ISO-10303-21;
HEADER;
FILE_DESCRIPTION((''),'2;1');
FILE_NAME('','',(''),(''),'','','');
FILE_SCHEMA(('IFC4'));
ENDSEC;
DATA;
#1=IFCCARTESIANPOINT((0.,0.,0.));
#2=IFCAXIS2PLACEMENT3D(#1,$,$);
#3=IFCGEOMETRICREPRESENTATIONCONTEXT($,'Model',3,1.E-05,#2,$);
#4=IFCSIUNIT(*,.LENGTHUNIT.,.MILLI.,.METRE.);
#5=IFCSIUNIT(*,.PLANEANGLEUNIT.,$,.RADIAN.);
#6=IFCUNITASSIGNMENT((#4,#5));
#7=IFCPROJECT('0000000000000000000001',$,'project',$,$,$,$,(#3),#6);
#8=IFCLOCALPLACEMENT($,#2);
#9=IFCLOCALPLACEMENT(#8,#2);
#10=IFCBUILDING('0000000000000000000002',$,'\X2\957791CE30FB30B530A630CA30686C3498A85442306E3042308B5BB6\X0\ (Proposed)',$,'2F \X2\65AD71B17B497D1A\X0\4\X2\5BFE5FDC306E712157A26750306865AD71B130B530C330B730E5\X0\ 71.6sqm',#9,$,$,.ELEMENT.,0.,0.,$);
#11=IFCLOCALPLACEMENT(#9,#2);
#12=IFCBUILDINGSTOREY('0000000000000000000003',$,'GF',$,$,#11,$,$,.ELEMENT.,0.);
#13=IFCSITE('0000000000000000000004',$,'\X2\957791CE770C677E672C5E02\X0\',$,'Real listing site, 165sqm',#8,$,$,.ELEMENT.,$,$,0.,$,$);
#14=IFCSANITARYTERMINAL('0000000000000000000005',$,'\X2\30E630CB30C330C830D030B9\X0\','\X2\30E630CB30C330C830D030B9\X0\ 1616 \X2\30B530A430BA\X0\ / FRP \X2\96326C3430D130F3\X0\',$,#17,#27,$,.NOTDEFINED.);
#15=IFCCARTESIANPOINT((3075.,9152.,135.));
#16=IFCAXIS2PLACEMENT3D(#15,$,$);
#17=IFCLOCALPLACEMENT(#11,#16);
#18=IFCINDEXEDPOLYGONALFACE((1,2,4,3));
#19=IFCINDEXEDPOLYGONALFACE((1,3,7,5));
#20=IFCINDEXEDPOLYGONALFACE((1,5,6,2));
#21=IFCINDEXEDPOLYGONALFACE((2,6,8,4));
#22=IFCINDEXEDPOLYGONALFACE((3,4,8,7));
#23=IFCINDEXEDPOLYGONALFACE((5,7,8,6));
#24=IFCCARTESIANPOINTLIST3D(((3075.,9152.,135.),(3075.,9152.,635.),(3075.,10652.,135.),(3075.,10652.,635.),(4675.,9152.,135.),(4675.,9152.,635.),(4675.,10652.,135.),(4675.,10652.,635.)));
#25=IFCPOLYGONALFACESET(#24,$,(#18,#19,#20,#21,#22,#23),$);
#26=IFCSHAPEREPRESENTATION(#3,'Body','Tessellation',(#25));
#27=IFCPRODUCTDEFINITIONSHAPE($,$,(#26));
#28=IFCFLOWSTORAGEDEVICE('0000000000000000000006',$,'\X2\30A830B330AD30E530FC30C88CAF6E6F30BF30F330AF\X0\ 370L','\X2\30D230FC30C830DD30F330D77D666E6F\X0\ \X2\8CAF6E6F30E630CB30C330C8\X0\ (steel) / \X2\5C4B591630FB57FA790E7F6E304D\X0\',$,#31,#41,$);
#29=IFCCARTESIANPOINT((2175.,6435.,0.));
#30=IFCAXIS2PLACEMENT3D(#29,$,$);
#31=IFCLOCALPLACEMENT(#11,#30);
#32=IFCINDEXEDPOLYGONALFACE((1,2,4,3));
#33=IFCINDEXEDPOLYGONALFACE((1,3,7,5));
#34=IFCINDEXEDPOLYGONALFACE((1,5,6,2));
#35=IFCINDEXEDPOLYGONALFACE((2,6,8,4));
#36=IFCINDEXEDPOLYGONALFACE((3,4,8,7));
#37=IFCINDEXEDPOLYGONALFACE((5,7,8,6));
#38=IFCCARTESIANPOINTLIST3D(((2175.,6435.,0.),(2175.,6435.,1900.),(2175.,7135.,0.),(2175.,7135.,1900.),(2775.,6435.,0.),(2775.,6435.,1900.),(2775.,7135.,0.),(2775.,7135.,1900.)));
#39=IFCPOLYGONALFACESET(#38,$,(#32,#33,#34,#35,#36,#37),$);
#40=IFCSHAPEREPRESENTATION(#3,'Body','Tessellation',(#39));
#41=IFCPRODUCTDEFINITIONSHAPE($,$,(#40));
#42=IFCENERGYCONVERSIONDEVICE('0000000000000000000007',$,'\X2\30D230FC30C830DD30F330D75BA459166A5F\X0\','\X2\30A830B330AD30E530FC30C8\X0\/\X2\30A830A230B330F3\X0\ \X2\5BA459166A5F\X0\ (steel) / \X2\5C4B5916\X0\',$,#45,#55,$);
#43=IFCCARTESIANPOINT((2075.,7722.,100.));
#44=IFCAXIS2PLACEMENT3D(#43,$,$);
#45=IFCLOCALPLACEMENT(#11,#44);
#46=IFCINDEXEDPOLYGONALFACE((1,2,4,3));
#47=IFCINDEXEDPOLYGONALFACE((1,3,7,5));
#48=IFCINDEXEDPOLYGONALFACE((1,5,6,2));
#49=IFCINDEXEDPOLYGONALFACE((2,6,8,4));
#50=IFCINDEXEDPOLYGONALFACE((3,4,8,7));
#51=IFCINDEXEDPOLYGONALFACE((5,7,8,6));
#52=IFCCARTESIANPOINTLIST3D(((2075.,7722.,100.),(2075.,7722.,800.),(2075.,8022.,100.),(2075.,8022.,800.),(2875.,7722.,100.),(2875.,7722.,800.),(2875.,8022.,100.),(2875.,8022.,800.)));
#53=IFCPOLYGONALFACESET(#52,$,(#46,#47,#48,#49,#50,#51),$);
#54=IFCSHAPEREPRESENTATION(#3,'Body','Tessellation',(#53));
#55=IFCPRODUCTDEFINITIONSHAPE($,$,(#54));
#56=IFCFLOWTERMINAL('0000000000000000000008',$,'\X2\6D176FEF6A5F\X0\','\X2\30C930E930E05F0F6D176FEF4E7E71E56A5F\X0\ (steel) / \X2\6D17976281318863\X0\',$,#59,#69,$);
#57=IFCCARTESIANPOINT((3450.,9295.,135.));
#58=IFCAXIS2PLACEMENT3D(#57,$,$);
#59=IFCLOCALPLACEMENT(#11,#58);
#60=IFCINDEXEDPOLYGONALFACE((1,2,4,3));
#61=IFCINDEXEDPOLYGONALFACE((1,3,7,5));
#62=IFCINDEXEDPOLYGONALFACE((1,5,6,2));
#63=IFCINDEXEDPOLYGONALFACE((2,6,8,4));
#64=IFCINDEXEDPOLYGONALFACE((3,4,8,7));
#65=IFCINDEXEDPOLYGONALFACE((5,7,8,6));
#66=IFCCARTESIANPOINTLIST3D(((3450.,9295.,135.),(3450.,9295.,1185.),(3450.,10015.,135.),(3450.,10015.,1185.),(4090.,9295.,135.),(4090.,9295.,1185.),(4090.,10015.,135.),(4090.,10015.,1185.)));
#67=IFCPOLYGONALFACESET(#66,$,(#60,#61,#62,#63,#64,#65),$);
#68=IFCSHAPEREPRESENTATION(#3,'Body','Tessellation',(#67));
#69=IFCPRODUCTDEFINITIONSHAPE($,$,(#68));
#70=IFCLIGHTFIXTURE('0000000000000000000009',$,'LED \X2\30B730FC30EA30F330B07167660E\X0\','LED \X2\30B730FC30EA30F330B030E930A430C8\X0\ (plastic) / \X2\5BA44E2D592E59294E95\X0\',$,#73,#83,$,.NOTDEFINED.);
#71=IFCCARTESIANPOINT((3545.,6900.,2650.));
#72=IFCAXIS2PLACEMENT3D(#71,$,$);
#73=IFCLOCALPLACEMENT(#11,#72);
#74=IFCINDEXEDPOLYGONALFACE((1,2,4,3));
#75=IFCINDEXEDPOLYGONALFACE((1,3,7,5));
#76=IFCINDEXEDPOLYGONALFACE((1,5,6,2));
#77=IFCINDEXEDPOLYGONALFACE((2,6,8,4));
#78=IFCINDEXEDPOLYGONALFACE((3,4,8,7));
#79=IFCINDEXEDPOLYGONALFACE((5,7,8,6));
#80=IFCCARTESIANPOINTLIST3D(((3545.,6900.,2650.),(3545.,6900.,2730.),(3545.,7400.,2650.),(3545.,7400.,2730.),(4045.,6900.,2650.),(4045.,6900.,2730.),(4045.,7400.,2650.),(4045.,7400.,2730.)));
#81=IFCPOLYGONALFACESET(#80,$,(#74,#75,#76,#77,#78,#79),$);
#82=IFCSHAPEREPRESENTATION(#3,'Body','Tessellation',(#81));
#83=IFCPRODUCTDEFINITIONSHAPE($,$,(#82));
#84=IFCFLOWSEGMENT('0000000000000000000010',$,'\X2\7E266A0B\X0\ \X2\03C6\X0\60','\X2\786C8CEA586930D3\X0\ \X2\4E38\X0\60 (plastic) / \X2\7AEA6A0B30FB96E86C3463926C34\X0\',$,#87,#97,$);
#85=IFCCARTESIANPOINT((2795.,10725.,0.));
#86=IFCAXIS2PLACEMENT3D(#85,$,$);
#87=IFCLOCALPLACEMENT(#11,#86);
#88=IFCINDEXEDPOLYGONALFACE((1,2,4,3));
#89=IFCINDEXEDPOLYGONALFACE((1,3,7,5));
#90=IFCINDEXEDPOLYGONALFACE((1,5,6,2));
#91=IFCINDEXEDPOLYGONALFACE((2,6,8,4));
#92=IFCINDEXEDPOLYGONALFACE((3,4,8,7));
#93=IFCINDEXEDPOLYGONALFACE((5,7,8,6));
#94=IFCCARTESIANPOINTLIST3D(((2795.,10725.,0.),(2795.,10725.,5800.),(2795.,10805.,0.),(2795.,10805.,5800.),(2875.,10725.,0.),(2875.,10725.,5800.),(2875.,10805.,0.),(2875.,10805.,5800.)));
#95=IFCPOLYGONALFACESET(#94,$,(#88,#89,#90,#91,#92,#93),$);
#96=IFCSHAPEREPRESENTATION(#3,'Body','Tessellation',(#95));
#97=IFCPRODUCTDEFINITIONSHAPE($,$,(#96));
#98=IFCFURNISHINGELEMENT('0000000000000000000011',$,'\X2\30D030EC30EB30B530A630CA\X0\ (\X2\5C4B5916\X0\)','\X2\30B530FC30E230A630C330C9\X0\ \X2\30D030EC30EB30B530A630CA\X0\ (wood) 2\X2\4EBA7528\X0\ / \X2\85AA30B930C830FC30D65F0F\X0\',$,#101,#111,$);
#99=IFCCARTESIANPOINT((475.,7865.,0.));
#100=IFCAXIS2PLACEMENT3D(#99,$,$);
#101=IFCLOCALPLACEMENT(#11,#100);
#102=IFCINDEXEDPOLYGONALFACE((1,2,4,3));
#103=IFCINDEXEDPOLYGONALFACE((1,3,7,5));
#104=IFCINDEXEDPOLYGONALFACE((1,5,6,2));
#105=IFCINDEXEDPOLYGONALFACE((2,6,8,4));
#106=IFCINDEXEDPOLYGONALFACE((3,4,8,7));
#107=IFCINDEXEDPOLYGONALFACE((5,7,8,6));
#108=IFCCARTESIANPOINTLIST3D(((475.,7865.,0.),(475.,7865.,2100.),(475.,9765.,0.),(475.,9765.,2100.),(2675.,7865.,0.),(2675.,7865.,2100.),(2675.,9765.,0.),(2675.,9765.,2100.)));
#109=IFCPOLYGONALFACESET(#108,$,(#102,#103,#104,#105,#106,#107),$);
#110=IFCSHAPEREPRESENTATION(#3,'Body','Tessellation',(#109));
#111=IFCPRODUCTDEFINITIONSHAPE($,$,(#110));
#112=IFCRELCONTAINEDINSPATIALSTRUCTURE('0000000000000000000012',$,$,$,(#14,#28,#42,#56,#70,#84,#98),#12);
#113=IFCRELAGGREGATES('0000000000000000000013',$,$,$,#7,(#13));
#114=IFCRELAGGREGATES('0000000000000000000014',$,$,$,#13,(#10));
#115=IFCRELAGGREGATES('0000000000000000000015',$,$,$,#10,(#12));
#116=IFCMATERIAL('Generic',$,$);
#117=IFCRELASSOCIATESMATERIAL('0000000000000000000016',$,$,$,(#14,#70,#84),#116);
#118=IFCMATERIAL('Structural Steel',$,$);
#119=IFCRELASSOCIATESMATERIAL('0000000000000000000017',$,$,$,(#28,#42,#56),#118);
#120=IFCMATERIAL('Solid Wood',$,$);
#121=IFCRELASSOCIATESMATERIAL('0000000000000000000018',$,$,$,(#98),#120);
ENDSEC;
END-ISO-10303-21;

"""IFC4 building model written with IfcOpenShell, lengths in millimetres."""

from ifc_helpers import new_model, si_unit, frame, frame_2d, origin, place, context, project, spatial, rectangle, extrude, material, element, save


model = new_model("IFC4")

# Units and contexts
model_context = context("Model", 3, precision=1e-05, world=origin())
ifc_project = project(units=[si_unit("LENGTHUNIT", "METRE", prefix="MILLI"), si_unit("PLANEANGLEUNIT", "RADIAN")], contexts=[model_context])

# Site, building, storey
site_placement = place(None, origin())
site = spatial("IfcSite", under=ifc_project, at=site_placement, Name="長野県松本市", ObjectType="Real listing site, 165sqm", CompositionType="ELEMENT", RefElevation=0.0)
building_placement = place(site_placement, origin())
building = spatial("IfcBuilding", under=site, at=building_placement, Name="長野・サウナと水風呂のある家 (Proposed)", ObjectType="2F 断熱等級4対応の無垢材と断熱サッシュ 71.6sqm", CompositionType="ELEMENT", ElevationOfRefHeight=0.0, ElevationOfTerrain=0.0)
storey_placement = place(building_placement, origin())
storey = spatial("IfcBuildingStorey", under=building, at=storey_placement, Name="GF", CompositionType="ELEMENT", Elevation=0.0)

# Shared definitions
ifc_material_1 = material(Name="Solid Wood")

# Shared definitions
ifc_material_2 = material(Name="Generic")

# Sanitary terminal
sanitary_terminal_placement = place(storey_placement, frame((3075.0, 9152.0, 135.0)))
element("IfcSanitaryTerminal", 1, at=sanitary_terminal_placement, inside=storey, material=ifc_material_2, Name="ユニットバス", Description="ユニットバス 1616 サイズ / FRP 防水パン", PredefinedType="NOTDEFINED", context=model_context, shape_type="SweptSolid", body=[
    extrude(rectangle(XDim=1600.0, YDim=1500.0, at=frame_2d((800.0, 750.0))), frame((3075.0, 9152.0, 135.0)), (0.0, 0.0, 1.0), 500.0),
])

# Flow storage device
ifc_material_3 = material(Name="Structural Steel")
flow_storage_device_placement = place(storey_placement, frame((2175.0, 6435.0, 0.0)))
element("IfcFlowStorageDevice", 2, at=flow_storage_device_placement, inside=storey, material=ifc_material_3, Name="エコキュート貯湯タンク 370L", Description="ヒートポンプ給湯 貯湯ユニット (steel) / 屋外・基礎置き", context=model_context, shape_type="SweptSolid", body=[
    extrude(rectangle(XDim=600.0, YDim=700.0, at=frame_2d((300.0, 350.0))), frame((2175.0, 6435.0, 0.0)), (0.0, 0.0, 1.0), 1900.0),
])

# Energy conversion device
energy_conversion_device_placement = place(storey_placement, frame((2075.0, 7722.0, 100.0)))
element("IfcEnergyConversionDevice", 3, at=energy_conversion_device_placement, inside=storey, material=ifc_material_3, Name="ヒートポンプ室外機", Description="エコキュート/エアコン 室外機 (steel) / 屋外", context=model_context, shape_type="SweptSolid", body=[
    extrude(rectangle(XDim=800.0, YDim=300.0, at=frame_2d((400.0, 150.0))), frame((2075.0, 7722.0, 100.0)), (0.0, 0.0, 1.0), 700.0),
])

# Flow terminal
flow_terminal_placement = place(storey_placement, frame((3450.0, 9295.0, 135.0)))
element("IfcFlowTerminal", 4, at=flow_terminal_placement, inside=storey, material=ifc_material_3, Name="洗濯機", Description="ドラム式洗濯乾燥機 (steel) / 洗面脱衣", context=model_context, shape_type="SweptSolid", body=[
    extrude(rectangle(XDim=640.0, YDim=720.0, at=frame_2d((320.0, 360.0))), frame((3450.0, 9295.0, 135.0)), (0.0, 0.0, 1.0), 1050.0),
])

# Light fixture
light_fixture_placement = place(storey_placement, frame((3545.0, 6900.0, 2650.0)))
element("IfcLightFixture", 5, at=light_fixture_placement, inside=storey, material=ifc_material_2, Name="LED シーリング照明", Description="LED シーリングライト (plastic) / 室中央天井", PredefinedType="NOTDEFINED", context=model_context, shape_type="SweptSolid", body=[
    extrude(rectangle(XDim=500.0, YDim=500.0, at=frame_2d((250.0, 250.0))), frame((3545.0, 6900.0, 2650.0)), (0.0, 0.0, 1.0), 80.0),
])

# Flow segment
flow_segment_placement = place(storey_placement, frame((2795.0, 10725.0, 0.0)))
element("IfcFlowSegment", 6, at=flow_segment_placement, inside=storey, material=ifc_material_2, Name="縦樋 φ60", Description="硬質塩ビ 丸60 (plastic) / 竪樋・雨水排水", context=model_context, shape_type="SweptSolid", body=[
    extrude(rectangle(XDim=80.0, YDim=80.0, at=frame_2d((40.0, 40.0))), frame((2795.0, 10725.0, 0.0)), (0.0, 0.0, 1.0), 5800.0),
])

# Furnishing element
furnishing_placement = place(storey_placement, frame((475.0, 7865.0, 0.0)))
element("IfcFurnishingElement", 7, at=furnishing_placement, inside=storey, material=ifc_material_1, Name="バレルサウナ (屋外)", Description="サーモウッド バレルサウナ (wood) 2人用 / 薪ストーブ式", context=model_context, shape_type="SweptSolid", body=[
    extrude(rectangle(XDim=2200.0, YDim=1900.0, at=frame_2d((1100.0, 950.0))), frame((475.0, 7865.0, 0.0)), (0.0, 0.0, 1.0), 2100.0),
])

save(model, "model.ifc")
